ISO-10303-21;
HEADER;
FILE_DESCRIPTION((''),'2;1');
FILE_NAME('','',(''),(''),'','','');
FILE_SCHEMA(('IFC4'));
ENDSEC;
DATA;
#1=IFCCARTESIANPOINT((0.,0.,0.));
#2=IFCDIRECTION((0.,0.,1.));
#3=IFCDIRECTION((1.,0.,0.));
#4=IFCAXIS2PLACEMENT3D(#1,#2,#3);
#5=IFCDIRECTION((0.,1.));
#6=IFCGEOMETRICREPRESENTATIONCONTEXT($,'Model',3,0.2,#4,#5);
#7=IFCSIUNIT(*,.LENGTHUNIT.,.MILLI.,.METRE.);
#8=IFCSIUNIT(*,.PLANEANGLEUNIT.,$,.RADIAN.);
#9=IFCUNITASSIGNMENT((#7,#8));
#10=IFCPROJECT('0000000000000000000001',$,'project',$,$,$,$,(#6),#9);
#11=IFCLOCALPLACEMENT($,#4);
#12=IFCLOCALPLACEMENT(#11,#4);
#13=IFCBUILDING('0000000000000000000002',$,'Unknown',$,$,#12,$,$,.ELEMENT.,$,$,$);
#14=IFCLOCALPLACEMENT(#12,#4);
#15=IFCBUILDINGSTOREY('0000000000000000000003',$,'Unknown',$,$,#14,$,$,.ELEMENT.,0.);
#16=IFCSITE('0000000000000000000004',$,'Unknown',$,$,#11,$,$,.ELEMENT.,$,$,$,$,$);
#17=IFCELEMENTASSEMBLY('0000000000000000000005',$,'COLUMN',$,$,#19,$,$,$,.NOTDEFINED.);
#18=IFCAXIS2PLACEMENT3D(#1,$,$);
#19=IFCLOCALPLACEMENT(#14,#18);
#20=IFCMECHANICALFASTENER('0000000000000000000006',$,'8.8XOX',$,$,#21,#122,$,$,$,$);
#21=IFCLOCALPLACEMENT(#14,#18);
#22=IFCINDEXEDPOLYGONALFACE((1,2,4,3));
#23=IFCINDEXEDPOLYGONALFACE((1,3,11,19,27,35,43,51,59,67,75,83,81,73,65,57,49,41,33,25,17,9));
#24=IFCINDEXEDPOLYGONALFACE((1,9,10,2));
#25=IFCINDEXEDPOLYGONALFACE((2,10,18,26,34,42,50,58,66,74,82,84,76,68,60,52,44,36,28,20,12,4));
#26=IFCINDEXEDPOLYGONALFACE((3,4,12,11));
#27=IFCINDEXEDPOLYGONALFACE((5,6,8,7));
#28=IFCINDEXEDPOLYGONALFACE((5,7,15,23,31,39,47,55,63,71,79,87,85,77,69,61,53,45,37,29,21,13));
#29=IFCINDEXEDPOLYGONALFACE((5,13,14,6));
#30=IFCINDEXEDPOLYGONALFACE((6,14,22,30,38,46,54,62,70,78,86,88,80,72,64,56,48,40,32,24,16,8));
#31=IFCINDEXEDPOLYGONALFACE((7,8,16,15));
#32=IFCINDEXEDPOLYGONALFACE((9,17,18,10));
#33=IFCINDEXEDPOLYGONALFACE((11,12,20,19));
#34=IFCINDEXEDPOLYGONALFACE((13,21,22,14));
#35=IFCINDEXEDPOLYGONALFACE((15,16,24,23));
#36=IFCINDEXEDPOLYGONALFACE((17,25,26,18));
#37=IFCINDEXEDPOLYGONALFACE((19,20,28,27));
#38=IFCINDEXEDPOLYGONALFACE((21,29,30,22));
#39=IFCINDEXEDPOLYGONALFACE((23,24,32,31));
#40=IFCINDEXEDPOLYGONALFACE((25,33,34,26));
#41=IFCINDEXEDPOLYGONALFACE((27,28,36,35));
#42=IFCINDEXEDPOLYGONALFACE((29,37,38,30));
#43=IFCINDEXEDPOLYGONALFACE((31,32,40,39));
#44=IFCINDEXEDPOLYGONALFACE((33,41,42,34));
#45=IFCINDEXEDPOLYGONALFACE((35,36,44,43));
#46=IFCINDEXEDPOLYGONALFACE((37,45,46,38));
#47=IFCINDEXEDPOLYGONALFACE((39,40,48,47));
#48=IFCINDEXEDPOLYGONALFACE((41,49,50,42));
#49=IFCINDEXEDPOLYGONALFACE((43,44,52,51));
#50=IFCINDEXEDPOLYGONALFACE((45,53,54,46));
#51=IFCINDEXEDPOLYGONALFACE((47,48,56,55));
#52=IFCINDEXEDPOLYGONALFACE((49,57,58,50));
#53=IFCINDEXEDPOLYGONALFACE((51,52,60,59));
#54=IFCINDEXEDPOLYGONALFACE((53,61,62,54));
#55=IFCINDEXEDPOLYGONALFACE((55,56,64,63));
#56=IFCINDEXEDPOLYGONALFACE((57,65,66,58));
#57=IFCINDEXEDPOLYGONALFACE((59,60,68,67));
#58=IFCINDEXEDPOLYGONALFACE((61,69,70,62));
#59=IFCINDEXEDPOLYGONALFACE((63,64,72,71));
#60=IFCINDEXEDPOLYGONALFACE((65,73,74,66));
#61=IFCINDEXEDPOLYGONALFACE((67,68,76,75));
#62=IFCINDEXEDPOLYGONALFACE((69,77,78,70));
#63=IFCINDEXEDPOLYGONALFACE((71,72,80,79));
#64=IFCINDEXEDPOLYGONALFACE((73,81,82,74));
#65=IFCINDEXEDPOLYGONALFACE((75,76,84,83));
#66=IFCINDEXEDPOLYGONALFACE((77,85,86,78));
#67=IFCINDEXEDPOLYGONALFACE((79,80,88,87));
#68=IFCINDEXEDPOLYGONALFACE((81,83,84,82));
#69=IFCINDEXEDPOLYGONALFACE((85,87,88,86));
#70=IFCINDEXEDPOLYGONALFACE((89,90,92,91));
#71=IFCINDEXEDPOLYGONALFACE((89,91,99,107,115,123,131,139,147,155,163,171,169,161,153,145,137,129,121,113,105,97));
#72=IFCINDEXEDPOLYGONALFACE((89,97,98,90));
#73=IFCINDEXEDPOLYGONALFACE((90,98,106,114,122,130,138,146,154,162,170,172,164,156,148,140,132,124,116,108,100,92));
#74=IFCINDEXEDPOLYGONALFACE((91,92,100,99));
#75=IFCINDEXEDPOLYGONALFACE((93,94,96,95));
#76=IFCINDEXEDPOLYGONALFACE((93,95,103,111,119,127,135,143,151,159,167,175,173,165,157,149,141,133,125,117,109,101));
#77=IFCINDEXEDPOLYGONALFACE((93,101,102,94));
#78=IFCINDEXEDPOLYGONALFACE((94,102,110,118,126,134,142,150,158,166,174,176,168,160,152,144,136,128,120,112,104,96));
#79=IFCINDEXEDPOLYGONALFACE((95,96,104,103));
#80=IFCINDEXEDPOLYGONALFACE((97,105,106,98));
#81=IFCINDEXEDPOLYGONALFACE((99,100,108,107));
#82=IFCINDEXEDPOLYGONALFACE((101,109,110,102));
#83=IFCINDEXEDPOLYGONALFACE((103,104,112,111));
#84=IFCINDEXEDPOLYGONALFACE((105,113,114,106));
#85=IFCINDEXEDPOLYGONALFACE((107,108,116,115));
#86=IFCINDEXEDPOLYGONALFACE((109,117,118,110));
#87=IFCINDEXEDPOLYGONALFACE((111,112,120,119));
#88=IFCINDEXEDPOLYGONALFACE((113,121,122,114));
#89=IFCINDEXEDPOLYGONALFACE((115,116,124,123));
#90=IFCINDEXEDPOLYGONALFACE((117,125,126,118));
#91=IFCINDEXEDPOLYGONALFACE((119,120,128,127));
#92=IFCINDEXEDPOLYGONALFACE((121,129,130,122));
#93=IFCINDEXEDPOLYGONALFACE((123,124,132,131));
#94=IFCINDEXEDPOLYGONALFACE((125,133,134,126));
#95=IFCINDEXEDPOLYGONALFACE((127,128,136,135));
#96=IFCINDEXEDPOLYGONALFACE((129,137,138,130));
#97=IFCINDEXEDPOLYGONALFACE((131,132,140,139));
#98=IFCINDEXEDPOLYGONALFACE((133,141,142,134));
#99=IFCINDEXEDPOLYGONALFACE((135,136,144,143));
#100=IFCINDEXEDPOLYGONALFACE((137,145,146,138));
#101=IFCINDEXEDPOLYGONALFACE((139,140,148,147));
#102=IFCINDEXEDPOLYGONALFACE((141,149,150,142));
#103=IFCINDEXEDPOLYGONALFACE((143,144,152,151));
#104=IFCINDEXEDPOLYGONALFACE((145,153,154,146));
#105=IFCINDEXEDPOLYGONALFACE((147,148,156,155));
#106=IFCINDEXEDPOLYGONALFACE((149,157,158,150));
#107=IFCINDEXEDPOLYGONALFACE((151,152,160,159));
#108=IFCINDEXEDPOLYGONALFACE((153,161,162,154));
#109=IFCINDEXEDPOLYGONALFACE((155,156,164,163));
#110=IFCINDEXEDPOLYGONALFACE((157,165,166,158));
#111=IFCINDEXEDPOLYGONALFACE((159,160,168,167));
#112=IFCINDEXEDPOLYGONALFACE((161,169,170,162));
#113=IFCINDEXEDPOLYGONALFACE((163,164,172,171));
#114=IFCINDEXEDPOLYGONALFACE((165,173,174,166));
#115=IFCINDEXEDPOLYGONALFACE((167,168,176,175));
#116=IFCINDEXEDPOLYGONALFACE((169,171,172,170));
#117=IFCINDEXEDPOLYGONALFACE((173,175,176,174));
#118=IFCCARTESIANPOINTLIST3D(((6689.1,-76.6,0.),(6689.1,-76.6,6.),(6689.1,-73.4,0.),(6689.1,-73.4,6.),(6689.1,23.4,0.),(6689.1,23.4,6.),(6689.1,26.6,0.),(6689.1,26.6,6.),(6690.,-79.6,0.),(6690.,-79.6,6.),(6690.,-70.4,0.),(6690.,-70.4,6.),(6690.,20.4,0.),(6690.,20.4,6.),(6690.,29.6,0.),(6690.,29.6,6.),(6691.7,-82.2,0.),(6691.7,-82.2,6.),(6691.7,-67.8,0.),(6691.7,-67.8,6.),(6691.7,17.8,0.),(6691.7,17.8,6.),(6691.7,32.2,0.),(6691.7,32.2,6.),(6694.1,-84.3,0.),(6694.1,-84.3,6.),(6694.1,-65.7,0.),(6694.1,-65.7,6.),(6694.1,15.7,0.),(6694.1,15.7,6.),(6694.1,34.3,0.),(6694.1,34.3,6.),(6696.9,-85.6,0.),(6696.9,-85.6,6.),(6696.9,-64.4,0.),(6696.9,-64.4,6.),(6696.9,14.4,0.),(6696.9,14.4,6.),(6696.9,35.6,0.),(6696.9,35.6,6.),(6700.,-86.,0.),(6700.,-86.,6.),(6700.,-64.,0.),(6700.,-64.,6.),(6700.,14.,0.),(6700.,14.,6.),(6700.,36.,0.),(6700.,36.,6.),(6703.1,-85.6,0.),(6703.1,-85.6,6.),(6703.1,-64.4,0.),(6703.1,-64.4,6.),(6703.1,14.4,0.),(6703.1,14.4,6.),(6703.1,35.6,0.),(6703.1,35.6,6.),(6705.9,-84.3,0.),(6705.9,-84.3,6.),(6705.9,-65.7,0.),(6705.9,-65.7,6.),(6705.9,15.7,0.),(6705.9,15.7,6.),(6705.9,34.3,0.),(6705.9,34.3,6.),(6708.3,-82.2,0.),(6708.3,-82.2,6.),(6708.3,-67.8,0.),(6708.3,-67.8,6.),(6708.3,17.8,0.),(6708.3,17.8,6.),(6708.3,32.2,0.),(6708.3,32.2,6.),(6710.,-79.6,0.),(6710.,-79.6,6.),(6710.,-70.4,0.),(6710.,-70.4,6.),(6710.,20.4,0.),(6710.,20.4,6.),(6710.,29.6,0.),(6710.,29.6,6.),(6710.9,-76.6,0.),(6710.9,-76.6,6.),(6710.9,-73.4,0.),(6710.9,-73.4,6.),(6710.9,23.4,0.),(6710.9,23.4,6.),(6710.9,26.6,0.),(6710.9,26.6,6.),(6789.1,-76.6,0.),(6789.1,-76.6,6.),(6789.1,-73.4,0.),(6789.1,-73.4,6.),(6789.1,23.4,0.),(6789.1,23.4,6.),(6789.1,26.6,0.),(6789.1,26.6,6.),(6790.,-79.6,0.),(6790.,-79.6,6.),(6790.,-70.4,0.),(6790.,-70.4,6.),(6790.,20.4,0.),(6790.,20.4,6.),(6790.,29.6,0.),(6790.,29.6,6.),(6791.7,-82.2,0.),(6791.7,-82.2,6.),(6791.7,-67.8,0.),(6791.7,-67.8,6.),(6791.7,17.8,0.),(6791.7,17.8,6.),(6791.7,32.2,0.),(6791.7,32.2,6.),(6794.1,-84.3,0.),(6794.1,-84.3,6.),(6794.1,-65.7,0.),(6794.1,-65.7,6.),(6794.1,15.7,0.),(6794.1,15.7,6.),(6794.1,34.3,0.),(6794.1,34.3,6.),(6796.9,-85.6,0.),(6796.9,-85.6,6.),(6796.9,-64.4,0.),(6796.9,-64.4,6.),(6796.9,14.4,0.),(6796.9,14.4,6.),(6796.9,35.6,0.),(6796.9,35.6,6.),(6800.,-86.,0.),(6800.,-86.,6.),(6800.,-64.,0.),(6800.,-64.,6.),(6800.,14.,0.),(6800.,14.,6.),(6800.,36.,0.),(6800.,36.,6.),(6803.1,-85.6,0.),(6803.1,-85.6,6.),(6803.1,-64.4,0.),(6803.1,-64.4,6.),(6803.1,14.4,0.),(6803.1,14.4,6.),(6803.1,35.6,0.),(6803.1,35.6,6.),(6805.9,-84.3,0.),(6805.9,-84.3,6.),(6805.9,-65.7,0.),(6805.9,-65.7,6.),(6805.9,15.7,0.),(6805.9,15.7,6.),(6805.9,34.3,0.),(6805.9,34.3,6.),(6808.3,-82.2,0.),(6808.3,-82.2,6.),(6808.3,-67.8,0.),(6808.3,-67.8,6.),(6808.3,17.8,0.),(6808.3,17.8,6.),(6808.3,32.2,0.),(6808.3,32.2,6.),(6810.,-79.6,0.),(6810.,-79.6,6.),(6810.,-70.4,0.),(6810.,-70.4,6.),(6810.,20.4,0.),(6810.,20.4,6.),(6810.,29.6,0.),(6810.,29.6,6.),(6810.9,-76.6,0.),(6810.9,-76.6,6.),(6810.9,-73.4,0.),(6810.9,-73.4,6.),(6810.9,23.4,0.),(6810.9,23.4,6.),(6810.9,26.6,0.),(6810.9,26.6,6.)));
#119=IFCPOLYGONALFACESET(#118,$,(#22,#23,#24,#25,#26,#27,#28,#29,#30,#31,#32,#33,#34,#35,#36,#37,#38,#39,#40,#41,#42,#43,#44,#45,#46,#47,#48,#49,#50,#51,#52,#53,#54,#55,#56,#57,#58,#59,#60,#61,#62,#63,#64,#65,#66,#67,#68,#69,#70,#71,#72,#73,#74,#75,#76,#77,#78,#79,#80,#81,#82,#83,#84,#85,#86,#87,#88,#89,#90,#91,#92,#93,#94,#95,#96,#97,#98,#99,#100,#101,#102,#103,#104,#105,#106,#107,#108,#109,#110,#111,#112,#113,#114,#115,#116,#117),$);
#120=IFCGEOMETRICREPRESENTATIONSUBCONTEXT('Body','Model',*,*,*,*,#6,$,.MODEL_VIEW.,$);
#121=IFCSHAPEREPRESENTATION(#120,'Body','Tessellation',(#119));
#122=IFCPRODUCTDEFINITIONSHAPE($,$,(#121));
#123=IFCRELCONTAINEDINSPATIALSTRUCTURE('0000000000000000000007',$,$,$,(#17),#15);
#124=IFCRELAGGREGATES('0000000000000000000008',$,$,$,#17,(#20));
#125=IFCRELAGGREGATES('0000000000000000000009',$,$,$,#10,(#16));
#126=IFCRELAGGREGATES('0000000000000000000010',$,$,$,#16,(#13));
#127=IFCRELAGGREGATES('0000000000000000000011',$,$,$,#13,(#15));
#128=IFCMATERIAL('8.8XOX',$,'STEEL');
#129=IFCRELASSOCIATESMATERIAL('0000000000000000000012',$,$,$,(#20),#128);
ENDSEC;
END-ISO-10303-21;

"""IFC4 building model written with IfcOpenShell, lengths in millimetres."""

from ifc_helpers import new_model, si_unit, direction, frame, origin_with_axes, place, context, subcontext, project, spatial, arc, indexed_curve, outline, extrude, source, transform, mapped, material, element, aggregate, save


model = new_model("IFC4")

# Units and contexts
model_context = context("Model", 3, precision=0.2, world=origin_with_axes(), true_north=direction((0.0, 1.0)))
body_context = subcontext(model_context, "Body", "Model", "MODEL_VIEW")
ifc_project = project(units=[si_unit("LENGTHUNIT", "METRE", prefix="MILLI"), si_unit("PLANEANGLEUNIT", "RADIAN")], contexts=[model_context])

# Site, building, storey
site_placement = place(None, origin_with_axes())
site = spatial("IfcSite", under=ifc_project, at=site_placement, Name="Unknown", CompositionType="ELEMENT")
building_placement = place(site_placement, origin_with_axes())
building = spatial("IfcBuilding", under=site, at=building_placement, Name="Unknown", CompositionType="ELEMENT")
storey_placement = place(building_placement, origin_with_axes())
storey = spatial("IfcBuildingStorey", under=building, at=storey_placement, Name="Unknown", CompositionType="ELEMENT", Elevation=0.0)

# Element assembly
assembly_1_placement = place(storey_placement, frame((6750.0, -25.0, 0.0), z_axis=(0.0, 1.0, 0.0), x_axis=(0.0, 0.0, 1.0)))
assembly_1 = element("IfcElementAssembly", 1, at=assembly_1_placement, inside=storey, Name="COLUMN", PredefinedType="NOTDEFINED")

# Shared definitions
ifc_material_1 = material(Name="8.8XOX", Category="STEEL")

# Mechanical fastener
shared_shape_1 = source(origin_with_axes(), body_context, "Body", "SweptSolid", [
    extrude(outline(indexed_curve([(11.0, 0.0), (0.0, 11.0), (-11.0, 0.0), (0.0, -11.0)], segments=[arc(1, 2, 3), arc(3, 4, 1)])), frame((0.0, 0.0, 0.0), z_axis=(0.0, 0.0, -1.0), x_axis=(0.0, 1.0, 0.0)), (0.0, 0.0, 1.0), 6.0),
])
mechanical_fastener_1_placement = place(assembly_1_placement, frame((6.0, 25.0, 0.0), z_axis=(1.0, 0.0, 0.0), x_axis=(0.0, -1.0, 0.0)))
mechanical_fastener_1 = element("IfcMechanicalFastener", 2, at=mechanical_fastener_1_placement, material=ifc_material_1, Name="8.8XOX", context=body_context, shape_type="MappedRepresentation", body=[
    mapped(shared_shape_1, transform((-25.0, 50.0, 0.0))),
    mapped(shared_shape_1, transform((-25.0, -50.0, 0.0))),
    mapped(shared_shape_1, transform((75.0, 50.0, 0.0))),
    mapped(shared_shape_1, transform((75.0, -50.0, 0.0))),
])
aggregate(assembly_1, [mechanical_fastener_1])

save(model, "model.ifc")
